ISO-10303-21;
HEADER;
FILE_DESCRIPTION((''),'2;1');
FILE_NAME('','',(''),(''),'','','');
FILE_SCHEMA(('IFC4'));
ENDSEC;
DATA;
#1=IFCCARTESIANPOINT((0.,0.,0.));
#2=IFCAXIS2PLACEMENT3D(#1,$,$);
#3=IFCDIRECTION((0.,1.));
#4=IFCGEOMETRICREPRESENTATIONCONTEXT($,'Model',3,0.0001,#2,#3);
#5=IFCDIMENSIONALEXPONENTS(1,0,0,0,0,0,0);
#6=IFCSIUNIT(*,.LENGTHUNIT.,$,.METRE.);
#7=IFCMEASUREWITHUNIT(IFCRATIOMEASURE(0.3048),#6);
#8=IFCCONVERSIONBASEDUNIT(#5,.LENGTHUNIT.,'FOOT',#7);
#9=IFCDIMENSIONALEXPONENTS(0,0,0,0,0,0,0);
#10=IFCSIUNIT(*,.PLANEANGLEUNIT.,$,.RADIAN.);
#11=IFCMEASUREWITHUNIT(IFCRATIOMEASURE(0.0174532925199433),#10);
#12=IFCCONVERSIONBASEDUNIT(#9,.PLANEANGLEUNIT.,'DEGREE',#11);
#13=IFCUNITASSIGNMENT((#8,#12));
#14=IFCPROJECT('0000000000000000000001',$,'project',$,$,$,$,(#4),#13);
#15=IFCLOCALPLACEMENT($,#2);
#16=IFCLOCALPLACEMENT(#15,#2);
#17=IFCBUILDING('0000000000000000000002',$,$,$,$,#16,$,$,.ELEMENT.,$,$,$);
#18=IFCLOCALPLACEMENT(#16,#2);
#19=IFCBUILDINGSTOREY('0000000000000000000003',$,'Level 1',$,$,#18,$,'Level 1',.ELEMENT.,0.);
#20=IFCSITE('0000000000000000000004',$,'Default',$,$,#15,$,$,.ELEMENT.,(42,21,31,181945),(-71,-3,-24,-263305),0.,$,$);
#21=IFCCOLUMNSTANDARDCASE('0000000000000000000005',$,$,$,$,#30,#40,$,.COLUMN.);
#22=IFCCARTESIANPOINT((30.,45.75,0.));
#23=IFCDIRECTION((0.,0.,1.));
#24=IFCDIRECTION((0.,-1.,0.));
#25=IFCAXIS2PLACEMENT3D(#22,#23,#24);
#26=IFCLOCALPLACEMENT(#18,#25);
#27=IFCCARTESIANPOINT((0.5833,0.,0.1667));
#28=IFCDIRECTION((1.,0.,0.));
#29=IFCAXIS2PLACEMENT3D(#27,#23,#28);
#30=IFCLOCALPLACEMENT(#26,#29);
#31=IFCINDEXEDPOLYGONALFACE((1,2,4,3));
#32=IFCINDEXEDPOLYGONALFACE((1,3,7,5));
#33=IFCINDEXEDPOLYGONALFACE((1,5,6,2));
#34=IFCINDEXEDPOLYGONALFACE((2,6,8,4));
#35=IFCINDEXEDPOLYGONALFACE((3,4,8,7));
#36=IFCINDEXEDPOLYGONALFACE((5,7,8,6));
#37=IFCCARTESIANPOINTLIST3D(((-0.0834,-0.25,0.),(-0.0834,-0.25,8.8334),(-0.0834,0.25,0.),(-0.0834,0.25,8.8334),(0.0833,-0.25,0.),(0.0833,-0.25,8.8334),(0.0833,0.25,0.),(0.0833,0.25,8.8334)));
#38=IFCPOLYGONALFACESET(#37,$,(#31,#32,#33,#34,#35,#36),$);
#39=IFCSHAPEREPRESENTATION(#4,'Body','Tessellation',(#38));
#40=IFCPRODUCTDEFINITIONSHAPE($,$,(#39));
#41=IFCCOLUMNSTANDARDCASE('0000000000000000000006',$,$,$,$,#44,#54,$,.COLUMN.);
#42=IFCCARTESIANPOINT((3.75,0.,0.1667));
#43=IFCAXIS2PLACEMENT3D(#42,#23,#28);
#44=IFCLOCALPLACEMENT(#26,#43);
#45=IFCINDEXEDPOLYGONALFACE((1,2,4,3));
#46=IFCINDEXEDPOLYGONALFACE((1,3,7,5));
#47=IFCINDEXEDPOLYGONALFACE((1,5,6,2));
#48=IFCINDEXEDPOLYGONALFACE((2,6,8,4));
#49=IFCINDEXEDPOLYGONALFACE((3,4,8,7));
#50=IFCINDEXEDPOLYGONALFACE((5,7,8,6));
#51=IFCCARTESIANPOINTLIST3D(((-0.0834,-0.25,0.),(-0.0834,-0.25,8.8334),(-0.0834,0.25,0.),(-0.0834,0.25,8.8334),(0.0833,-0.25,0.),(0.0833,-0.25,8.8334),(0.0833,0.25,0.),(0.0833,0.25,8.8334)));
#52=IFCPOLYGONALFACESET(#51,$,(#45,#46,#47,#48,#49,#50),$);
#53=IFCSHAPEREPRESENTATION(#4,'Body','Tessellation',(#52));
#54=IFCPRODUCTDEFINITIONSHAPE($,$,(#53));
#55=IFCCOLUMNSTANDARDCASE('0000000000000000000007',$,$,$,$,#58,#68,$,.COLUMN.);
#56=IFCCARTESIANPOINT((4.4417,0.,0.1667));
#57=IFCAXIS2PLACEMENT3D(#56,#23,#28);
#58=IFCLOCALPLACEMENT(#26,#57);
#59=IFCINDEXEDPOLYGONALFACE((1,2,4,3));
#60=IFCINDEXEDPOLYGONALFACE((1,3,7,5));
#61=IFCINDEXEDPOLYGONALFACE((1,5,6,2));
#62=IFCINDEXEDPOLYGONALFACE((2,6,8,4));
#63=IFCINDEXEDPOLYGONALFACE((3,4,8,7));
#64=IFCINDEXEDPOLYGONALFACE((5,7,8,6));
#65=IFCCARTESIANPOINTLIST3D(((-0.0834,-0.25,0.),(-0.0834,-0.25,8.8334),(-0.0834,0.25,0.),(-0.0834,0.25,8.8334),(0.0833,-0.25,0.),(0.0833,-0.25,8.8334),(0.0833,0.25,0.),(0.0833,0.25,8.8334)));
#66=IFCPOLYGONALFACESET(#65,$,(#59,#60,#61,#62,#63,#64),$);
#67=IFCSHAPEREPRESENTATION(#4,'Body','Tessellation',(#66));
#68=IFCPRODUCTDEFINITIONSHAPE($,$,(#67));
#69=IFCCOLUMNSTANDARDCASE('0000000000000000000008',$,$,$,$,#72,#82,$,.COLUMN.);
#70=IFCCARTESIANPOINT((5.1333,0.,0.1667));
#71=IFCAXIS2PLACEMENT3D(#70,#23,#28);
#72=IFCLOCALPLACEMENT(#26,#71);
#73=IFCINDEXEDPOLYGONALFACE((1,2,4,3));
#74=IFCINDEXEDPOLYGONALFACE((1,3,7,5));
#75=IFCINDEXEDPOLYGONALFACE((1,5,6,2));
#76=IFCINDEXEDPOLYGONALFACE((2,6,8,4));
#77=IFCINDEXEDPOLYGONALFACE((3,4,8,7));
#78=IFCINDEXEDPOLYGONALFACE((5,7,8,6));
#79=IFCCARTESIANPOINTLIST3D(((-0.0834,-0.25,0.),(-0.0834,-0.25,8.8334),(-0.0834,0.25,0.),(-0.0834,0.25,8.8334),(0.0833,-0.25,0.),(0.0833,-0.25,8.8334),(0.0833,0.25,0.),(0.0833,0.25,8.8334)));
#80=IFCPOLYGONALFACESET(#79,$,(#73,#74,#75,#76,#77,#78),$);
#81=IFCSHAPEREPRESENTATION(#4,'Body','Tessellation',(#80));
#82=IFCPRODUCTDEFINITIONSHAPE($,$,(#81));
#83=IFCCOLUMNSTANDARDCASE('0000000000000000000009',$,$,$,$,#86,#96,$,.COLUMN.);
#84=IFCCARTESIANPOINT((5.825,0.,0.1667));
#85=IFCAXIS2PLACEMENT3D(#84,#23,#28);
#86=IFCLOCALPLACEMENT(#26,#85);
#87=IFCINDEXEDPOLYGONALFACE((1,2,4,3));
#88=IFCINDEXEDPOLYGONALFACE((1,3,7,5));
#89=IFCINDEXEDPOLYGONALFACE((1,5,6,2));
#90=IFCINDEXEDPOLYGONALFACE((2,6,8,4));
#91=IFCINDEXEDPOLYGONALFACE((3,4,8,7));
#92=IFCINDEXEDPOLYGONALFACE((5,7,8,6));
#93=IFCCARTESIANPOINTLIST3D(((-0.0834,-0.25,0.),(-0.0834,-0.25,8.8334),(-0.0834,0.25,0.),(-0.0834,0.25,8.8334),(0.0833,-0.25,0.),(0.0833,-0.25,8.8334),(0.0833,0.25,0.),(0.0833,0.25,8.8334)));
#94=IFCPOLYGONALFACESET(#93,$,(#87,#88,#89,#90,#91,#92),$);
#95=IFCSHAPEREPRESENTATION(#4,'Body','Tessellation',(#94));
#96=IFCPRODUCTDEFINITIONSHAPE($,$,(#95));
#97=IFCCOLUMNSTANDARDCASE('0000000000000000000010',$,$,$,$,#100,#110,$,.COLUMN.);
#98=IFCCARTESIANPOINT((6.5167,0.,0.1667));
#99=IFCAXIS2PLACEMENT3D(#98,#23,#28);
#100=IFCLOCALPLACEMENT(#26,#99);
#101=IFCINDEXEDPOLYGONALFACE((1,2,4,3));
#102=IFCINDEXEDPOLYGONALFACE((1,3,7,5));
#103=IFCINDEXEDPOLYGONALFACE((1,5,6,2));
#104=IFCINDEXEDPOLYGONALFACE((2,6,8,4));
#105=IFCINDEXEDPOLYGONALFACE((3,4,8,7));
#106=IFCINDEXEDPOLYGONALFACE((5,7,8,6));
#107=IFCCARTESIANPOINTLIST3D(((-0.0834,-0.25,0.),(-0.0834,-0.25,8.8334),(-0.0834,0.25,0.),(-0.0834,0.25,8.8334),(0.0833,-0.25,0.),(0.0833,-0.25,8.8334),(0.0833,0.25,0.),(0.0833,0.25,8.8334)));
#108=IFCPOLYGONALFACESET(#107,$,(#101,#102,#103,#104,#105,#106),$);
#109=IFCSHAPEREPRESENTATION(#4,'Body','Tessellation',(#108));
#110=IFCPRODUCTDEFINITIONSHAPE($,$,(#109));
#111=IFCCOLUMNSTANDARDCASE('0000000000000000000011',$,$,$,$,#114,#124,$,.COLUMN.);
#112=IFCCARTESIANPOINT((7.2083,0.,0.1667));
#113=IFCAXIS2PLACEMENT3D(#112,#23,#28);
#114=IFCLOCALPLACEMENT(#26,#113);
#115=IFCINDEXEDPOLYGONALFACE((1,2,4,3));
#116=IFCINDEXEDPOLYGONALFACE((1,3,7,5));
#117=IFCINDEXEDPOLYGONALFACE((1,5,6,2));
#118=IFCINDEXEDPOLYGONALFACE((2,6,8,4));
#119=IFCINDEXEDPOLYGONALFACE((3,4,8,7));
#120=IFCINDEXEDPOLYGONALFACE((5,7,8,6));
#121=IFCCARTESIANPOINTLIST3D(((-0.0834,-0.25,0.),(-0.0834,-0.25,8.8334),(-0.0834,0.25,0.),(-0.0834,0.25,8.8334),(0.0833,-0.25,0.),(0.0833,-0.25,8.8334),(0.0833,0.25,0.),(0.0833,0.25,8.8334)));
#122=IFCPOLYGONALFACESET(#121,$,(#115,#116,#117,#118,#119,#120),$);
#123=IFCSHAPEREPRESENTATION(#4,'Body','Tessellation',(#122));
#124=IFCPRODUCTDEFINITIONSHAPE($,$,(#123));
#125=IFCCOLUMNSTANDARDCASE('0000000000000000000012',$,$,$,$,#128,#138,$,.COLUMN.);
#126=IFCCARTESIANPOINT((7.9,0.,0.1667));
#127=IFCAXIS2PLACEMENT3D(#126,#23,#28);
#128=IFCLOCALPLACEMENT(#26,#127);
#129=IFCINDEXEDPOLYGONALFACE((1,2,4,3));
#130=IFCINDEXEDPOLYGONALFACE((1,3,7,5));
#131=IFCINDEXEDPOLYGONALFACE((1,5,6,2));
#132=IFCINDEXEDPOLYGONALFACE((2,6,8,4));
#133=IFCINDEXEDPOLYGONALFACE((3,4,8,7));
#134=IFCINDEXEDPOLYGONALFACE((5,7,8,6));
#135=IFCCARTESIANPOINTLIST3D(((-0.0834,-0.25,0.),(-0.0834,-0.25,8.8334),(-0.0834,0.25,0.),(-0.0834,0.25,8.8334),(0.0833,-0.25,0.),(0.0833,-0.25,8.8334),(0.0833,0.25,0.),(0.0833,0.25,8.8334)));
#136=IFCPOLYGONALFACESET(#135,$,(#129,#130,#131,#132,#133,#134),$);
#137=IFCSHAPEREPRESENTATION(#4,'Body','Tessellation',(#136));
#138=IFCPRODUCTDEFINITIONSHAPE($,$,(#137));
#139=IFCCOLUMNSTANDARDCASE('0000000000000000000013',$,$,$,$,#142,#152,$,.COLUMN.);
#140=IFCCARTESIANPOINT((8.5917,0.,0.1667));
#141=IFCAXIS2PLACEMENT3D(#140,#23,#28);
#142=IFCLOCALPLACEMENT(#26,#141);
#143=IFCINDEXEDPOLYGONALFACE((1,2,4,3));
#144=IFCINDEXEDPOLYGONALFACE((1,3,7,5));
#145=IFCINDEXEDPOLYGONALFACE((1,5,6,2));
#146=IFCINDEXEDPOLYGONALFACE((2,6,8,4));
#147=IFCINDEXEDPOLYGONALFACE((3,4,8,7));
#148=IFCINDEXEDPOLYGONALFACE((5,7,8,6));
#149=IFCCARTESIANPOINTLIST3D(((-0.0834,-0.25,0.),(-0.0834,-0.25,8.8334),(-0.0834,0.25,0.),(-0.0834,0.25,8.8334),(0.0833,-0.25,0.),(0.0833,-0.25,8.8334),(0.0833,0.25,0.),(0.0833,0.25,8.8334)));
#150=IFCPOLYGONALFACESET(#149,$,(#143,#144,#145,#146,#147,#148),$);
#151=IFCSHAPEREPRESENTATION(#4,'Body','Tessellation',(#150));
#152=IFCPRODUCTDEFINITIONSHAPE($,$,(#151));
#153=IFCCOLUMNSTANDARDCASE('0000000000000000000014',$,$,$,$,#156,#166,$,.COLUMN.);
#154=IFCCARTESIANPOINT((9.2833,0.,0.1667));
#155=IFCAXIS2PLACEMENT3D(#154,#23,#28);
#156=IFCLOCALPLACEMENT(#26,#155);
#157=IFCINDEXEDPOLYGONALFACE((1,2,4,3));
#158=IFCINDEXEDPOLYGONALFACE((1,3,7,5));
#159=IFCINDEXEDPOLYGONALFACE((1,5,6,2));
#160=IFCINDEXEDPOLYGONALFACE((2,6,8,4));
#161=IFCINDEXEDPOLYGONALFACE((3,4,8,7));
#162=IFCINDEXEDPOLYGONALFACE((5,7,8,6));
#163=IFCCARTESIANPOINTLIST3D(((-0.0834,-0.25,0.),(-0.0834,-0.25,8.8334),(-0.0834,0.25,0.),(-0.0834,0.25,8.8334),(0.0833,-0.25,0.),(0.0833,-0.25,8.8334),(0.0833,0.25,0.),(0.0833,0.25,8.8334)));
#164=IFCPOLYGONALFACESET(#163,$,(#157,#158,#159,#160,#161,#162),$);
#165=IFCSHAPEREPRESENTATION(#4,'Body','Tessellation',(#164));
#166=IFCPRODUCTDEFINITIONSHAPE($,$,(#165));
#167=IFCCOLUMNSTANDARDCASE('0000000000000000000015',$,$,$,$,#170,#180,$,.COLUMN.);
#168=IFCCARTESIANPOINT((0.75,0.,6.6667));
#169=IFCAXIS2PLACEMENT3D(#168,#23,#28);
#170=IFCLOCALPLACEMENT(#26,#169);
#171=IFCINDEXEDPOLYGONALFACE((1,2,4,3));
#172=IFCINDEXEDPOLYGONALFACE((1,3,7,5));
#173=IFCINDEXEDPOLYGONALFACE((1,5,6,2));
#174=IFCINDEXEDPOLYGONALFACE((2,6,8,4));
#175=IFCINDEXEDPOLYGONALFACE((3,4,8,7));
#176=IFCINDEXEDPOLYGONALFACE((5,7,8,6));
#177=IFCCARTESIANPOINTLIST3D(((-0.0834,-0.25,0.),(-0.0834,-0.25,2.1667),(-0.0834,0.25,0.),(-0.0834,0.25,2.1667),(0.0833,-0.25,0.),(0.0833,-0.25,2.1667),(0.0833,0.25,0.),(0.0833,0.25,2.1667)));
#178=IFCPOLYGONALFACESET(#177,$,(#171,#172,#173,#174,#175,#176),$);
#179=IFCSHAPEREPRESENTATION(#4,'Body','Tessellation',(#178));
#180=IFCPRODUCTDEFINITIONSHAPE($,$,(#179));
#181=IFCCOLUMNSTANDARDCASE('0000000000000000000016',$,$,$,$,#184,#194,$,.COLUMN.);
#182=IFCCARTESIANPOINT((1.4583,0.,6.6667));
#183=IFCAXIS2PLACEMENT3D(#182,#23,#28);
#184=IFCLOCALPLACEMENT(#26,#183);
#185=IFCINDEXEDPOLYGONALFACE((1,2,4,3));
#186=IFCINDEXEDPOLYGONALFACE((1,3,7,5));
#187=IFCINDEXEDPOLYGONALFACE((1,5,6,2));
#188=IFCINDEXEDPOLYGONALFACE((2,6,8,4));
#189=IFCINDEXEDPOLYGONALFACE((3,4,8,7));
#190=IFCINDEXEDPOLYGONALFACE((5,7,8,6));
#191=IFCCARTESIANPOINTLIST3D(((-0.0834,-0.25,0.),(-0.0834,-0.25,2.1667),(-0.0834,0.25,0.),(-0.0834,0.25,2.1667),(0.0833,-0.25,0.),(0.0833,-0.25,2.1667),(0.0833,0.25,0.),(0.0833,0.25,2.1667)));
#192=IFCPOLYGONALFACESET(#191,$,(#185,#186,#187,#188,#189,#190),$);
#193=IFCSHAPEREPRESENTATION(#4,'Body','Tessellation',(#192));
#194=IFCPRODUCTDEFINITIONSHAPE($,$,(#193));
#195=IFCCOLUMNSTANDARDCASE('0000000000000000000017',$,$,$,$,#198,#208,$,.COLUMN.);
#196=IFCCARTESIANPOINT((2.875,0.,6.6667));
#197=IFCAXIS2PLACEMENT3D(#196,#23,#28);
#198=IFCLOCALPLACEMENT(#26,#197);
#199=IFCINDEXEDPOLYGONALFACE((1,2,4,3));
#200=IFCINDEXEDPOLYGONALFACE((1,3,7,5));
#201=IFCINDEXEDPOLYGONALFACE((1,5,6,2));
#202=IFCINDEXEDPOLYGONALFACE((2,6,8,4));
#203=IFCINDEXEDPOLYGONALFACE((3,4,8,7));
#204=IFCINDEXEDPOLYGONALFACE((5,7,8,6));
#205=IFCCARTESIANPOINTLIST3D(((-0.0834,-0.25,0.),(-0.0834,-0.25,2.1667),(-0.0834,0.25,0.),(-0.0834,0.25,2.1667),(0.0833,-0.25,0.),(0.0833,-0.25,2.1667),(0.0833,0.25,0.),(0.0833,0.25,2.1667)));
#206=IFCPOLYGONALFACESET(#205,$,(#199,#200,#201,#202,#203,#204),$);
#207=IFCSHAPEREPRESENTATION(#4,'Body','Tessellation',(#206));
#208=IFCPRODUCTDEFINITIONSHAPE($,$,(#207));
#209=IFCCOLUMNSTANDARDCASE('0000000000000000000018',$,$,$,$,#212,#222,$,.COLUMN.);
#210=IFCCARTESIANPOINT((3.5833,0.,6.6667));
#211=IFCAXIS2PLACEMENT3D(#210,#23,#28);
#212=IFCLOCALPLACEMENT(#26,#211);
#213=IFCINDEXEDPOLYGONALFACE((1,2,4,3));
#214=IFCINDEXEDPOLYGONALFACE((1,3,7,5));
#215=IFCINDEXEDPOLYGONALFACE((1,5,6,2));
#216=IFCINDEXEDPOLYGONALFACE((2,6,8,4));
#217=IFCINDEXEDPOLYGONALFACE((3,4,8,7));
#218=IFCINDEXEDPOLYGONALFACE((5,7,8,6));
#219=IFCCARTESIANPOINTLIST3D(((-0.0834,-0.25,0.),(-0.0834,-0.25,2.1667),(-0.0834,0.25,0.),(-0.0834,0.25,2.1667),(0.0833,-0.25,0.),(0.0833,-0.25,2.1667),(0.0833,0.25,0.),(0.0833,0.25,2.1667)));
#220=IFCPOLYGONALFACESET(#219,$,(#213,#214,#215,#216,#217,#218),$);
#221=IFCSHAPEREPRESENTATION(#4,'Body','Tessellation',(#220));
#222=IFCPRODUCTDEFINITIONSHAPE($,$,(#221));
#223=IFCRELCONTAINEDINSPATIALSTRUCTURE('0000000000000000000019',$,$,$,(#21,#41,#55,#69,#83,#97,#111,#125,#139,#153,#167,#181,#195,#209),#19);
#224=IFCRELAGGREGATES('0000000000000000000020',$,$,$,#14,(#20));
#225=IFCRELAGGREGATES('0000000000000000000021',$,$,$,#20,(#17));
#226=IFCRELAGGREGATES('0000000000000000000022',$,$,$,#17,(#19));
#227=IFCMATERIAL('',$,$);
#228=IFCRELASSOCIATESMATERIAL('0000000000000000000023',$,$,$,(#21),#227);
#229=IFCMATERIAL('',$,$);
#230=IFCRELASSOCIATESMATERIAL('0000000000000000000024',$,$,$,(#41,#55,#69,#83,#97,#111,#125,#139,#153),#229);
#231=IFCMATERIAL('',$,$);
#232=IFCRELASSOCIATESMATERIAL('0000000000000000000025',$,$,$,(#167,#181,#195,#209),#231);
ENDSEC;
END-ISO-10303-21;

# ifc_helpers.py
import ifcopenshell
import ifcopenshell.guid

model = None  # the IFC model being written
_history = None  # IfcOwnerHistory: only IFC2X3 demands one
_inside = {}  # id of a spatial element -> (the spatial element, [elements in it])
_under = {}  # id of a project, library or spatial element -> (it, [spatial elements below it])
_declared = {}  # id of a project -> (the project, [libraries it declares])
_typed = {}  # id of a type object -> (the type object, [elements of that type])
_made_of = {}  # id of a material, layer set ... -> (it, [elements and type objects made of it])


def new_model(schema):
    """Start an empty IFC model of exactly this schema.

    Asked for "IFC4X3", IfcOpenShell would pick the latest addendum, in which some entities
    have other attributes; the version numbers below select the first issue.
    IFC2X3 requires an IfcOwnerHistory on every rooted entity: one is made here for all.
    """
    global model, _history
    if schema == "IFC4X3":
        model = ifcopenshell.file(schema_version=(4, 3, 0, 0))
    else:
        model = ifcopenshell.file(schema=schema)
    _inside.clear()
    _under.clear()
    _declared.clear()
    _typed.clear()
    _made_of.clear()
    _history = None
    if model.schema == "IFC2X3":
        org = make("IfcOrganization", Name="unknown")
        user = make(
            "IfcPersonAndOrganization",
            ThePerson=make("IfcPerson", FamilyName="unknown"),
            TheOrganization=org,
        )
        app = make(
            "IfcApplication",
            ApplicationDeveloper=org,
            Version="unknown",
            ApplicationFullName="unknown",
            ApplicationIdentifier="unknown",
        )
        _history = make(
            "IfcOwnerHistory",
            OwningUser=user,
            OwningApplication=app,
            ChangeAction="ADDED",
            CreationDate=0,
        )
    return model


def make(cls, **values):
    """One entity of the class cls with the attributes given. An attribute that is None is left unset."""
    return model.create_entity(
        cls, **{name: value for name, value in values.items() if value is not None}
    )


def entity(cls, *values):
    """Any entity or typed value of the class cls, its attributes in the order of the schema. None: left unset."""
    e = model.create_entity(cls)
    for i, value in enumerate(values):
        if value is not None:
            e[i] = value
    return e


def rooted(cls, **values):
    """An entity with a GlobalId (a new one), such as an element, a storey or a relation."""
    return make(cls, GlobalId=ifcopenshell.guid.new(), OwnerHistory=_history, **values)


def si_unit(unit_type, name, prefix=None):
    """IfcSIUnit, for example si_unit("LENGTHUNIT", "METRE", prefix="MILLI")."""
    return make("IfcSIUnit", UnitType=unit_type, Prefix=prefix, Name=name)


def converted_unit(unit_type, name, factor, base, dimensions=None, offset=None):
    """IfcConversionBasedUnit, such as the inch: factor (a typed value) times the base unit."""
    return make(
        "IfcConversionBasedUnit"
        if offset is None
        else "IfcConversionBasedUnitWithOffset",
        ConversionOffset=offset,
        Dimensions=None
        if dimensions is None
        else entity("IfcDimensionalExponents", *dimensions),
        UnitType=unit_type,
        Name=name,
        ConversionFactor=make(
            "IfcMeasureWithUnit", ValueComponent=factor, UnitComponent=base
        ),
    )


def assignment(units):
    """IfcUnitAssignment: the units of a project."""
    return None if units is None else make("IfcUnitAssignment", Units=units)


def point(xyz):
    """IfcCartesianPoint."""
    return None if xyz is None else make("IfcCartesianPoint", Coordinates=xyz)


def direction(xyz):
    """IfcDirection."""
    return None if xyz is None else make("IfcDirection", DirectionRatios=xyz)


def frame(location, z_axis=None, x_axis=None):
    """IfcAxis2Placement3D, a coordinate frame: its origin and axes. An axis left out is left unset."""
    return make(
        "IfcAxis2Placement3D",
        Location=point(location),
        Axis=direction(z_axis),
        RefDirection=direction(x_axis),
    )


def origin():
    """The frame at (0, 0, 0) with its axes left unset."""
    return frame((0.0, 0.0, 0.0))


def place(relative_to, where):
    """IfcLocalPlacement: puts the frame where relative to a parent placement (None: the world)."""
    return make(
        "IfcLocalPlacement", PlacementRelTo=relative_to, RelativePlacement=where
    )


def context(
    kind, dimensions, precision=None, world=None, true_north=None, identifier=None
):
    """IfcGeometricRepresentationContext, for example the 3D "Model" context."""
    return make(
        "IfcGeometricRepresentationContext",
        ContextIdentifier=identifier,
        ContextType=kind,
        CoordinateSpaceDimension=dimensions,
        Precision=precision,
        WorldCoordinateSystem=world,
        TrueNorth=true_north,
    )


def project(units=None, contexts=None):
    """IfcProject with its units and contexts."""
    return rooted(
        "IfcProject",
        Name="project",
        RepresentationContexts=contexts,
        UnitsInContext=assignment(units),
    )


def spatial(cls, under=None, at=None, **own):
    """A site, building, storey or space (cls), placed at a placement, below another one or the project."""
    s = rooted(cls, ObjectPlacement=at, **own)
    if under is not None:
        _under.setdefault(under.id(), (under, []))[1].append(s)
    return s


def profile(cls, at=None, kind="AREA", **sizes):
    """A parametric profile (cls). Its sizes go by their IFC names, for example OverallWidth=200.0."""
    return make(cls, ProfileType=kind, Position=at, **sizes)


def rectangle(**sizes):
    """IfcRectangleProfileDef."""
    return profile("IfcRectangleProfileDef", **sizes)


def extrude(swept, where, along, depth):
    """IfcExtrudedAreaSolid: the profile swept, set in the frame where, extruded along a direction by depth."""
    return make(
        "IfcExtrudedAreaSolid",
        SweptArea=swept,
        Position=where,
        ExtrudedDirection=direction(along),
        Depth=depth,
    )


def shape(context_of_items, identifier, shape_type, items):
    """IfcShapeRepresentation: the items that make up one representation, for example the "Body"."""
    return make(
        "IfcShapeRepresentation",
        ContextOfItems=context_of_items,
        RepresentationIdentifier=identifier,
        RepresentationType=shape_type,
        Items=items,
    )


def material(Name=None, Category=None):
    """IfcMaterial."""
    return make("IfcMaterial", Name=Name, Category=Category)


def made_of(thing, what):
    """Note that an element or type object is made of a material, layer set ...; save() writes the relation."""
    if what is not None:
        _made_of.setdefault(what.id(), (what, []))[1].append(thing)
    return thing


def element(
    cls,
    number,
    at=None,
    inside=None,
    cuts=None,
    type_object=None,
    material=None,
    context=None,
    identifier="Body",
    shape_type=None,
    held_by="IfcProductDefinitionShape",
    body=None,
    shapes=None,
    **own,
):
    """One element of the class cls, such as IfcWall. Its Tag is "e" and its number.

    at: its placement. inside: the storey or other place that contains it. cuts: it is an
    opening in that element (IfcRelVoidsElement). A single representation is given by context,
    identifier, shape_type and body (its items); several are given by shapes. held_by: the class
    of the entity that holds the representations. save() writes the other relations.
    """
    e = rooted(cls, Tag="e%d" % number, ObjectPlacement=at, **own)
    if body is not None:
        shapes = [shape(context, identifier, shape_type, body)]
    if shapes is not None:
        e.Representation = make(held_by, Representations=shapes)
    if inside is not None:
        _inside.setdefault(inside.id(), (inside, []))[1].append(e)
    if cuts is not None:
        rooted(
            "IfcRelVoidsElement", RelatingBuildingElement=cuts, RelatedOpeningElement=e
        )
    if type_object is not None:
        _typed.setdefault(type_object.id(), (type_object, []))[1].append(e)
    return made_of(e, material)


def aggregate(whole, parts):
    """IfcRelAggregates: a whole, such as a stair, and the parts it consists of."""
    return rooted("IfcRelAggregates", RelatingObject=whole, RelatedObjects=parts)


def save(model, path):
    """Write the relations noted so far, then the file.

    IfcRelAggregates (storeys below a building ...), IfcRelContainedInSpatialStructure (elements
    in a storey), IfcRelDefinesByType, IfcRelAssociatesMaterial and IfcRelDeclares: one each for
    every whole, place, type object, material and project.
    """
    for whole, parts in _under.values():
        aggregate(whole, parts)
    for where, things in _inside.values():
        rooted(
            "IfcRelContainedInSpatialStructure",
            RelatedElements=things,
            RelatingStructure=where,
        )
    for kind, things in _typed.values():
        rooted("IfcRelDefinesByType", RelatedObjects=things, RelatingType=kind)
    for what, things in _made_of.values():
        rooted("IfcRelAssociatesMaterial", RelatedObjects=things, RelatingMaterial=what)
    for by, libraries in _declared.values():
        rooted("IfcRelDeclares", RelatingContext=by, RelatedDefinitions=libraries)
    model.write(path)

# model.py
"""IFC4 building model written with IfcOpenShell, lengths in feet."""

from ifc_helpers import new_model, entity, si_unit, converted_unit, direction, frame, origin, place, context, project, spatial, rectangle, extrude, material, element, save


model = new_model("IFC4")

# Units and contexts
model_context = context("Model", 3, precision=0.0001, world=origin(), true_north=direction((0.0, 1.0)))
ifc_project = project(units=[converted_unit("LENGTHUNIT", "FOOT", entity("IfcRatioMeasure", 0.3048), si_unit("LENGTHUNIT", "METRE"), dimensions=[1, 0, 0, 0, 0, 0, 0]), converted_unit("PLANEANGLEUNIT", "DEGREE", entity("IfcRatioMeasure", 0.0174532925199433), si_unit("PLANEANGLEUNIT", "RADIAN"), dimensions=[0, 0, 0, 0, 0, 0, 0])], contexts=[model_context])

# Site, building, storey
site_placement = place(None, origin())
site = spatial("IfcSite", under=ifc_project, at=site_placement, Name="Default", CompositionType="ELEMENT", RefLatitude=(42, 21, 31, 181945), RefLongitude=(-71, -3, -24, -263305), RefElevation=0.0)
building_placement = place(site_placement, origin())
building = spatial("IfcBuilding", under=site, at=building_placement, CompositionType="ELEMENT")
storey_placement = place(building_placement, origin())
storey = spatial("IfcBuildingStorey", under=building, at=storey_placement, Name="Level 1", LongName="Level 1", CompositionType="ELEMENT", Elevation=0.0)

# Columns
ifc_material_1 = material(Name="")
ifc_material_2 = material(Name="")
placement_1 = place(storey_placement, frame((30.0, 45.75, 0.0), z_axis=(0.0, 0.0, 1.0), x_axis=(0.0, -1.0, 0.0)))
for number, where, z_axis, x_axis in (
    (1, (0.5833, 0.0, 0.1667), (0.0, 0.0, 1.0), (1.0, 0.0, 0.0)),
):
    element("IfcColumnStandardCase", number, at=place(placement_1, frame(where, z_axis=z_axis, x_axis=x_axis)), inside=storey, material=ifc_material_2, PredefinedType="COLUMN", context=model_context, shape_type="SweptSolid", body=[
        extrude(rectangle(XDim=0.1667, YDim=0.5), origin(), (0.0, 0.0, 1.0), 8.8334),
    ])
for number, where, z_axis, x_axis in (
    (2, (3.75, 0.0, 0.1667), (0.0, 0.0, 1.0), (1.0, 0.0, 0.0)),
    (3, (4.4417, 0.0, 0.1667), (0.0, 0.0, 1.0), (1.0, 0.0, 0.0)),
    (4, (5.1333, 0.0, 0.1667), (0.0, 0.0, 1.0), (1.0, 0.0, 0.0)),
    (5, (5.825, 0.0, 0.1667), (0.0, 0.0, 1.0), (1.0, 0.0, 0.0)),
    (6, (6.5167, 0.0, 0.1667), (0.0, 0.0, 1.0), (1.0, 0.0, 0.0)),
    (7, (7.2083, 0.0, 0.1667), (0.0, 0.0, 1.0), (1.0, 0.0, 0.0)),
    (8, (7.9, 0.0, 0.1667), (0.0, 0.0, 1.0), (1.0, 0.0, 0.0)),
    (9, (8.5917, 0.0, 0.1667), (0.0, 0.0, 1.0), (1.0, 0.0, 0.0)),
    (10, (9.2833, 0.0, 0.1667), (0.0, 0.0, 1.0), (1.0, 0.0, 0.0)),
):
    element("IfcColumnStandardCase", number, at=place(placement_1, frame(where, z_axis=z_axis, x_axis=x_axis)), inside=storey, material=ifc_material_1, PredefinedType="COLUMN", context=model_context, shape_type="SweptSolid", body=[
        extrude(rectangle(XDim=0.1667, YDim=0.5), origin(), (0.0, 0.0, 1.0), 8.8334),
    ])
ifc_material_3 = material(Name="")
for number, where, z_axis, x_axis in (
    (11, (0.75, 0.0, 6.6667), (0.0, 0.0, 1.0), (1.0, 0.0, 0.0)),
    (12, (1.4583, 0.0, 6.6667), (0.0, 0.0, 1.0), (1.0, 0.0, 0.0)),
    (13, (2.875, 0.0, 6.6667), (0.0, 0.0, 1.0), (1.0, 0.0, 0.0)),
    (14, (3.5833, 0.0, 6.6667), (0.0, 0.0, 1.0), (1.0, 0.0, 0.0)),
):
    element("IfcColumnStandardCase", number, at=place(placement_1, frame(where, z_axis=z_axis, x_axis=x_axis)), inside=storey, material=ifc_material_3, PredefinedType="COLUMN", context=model_context, shape_type="SweptSolid", body=[
        extrude(rectangle(XDim=0.1667, YDim=0.5), origin(), (0.0, 0.0, 1.0), 2.1667),
    ])

save(model, "model.ifc")
